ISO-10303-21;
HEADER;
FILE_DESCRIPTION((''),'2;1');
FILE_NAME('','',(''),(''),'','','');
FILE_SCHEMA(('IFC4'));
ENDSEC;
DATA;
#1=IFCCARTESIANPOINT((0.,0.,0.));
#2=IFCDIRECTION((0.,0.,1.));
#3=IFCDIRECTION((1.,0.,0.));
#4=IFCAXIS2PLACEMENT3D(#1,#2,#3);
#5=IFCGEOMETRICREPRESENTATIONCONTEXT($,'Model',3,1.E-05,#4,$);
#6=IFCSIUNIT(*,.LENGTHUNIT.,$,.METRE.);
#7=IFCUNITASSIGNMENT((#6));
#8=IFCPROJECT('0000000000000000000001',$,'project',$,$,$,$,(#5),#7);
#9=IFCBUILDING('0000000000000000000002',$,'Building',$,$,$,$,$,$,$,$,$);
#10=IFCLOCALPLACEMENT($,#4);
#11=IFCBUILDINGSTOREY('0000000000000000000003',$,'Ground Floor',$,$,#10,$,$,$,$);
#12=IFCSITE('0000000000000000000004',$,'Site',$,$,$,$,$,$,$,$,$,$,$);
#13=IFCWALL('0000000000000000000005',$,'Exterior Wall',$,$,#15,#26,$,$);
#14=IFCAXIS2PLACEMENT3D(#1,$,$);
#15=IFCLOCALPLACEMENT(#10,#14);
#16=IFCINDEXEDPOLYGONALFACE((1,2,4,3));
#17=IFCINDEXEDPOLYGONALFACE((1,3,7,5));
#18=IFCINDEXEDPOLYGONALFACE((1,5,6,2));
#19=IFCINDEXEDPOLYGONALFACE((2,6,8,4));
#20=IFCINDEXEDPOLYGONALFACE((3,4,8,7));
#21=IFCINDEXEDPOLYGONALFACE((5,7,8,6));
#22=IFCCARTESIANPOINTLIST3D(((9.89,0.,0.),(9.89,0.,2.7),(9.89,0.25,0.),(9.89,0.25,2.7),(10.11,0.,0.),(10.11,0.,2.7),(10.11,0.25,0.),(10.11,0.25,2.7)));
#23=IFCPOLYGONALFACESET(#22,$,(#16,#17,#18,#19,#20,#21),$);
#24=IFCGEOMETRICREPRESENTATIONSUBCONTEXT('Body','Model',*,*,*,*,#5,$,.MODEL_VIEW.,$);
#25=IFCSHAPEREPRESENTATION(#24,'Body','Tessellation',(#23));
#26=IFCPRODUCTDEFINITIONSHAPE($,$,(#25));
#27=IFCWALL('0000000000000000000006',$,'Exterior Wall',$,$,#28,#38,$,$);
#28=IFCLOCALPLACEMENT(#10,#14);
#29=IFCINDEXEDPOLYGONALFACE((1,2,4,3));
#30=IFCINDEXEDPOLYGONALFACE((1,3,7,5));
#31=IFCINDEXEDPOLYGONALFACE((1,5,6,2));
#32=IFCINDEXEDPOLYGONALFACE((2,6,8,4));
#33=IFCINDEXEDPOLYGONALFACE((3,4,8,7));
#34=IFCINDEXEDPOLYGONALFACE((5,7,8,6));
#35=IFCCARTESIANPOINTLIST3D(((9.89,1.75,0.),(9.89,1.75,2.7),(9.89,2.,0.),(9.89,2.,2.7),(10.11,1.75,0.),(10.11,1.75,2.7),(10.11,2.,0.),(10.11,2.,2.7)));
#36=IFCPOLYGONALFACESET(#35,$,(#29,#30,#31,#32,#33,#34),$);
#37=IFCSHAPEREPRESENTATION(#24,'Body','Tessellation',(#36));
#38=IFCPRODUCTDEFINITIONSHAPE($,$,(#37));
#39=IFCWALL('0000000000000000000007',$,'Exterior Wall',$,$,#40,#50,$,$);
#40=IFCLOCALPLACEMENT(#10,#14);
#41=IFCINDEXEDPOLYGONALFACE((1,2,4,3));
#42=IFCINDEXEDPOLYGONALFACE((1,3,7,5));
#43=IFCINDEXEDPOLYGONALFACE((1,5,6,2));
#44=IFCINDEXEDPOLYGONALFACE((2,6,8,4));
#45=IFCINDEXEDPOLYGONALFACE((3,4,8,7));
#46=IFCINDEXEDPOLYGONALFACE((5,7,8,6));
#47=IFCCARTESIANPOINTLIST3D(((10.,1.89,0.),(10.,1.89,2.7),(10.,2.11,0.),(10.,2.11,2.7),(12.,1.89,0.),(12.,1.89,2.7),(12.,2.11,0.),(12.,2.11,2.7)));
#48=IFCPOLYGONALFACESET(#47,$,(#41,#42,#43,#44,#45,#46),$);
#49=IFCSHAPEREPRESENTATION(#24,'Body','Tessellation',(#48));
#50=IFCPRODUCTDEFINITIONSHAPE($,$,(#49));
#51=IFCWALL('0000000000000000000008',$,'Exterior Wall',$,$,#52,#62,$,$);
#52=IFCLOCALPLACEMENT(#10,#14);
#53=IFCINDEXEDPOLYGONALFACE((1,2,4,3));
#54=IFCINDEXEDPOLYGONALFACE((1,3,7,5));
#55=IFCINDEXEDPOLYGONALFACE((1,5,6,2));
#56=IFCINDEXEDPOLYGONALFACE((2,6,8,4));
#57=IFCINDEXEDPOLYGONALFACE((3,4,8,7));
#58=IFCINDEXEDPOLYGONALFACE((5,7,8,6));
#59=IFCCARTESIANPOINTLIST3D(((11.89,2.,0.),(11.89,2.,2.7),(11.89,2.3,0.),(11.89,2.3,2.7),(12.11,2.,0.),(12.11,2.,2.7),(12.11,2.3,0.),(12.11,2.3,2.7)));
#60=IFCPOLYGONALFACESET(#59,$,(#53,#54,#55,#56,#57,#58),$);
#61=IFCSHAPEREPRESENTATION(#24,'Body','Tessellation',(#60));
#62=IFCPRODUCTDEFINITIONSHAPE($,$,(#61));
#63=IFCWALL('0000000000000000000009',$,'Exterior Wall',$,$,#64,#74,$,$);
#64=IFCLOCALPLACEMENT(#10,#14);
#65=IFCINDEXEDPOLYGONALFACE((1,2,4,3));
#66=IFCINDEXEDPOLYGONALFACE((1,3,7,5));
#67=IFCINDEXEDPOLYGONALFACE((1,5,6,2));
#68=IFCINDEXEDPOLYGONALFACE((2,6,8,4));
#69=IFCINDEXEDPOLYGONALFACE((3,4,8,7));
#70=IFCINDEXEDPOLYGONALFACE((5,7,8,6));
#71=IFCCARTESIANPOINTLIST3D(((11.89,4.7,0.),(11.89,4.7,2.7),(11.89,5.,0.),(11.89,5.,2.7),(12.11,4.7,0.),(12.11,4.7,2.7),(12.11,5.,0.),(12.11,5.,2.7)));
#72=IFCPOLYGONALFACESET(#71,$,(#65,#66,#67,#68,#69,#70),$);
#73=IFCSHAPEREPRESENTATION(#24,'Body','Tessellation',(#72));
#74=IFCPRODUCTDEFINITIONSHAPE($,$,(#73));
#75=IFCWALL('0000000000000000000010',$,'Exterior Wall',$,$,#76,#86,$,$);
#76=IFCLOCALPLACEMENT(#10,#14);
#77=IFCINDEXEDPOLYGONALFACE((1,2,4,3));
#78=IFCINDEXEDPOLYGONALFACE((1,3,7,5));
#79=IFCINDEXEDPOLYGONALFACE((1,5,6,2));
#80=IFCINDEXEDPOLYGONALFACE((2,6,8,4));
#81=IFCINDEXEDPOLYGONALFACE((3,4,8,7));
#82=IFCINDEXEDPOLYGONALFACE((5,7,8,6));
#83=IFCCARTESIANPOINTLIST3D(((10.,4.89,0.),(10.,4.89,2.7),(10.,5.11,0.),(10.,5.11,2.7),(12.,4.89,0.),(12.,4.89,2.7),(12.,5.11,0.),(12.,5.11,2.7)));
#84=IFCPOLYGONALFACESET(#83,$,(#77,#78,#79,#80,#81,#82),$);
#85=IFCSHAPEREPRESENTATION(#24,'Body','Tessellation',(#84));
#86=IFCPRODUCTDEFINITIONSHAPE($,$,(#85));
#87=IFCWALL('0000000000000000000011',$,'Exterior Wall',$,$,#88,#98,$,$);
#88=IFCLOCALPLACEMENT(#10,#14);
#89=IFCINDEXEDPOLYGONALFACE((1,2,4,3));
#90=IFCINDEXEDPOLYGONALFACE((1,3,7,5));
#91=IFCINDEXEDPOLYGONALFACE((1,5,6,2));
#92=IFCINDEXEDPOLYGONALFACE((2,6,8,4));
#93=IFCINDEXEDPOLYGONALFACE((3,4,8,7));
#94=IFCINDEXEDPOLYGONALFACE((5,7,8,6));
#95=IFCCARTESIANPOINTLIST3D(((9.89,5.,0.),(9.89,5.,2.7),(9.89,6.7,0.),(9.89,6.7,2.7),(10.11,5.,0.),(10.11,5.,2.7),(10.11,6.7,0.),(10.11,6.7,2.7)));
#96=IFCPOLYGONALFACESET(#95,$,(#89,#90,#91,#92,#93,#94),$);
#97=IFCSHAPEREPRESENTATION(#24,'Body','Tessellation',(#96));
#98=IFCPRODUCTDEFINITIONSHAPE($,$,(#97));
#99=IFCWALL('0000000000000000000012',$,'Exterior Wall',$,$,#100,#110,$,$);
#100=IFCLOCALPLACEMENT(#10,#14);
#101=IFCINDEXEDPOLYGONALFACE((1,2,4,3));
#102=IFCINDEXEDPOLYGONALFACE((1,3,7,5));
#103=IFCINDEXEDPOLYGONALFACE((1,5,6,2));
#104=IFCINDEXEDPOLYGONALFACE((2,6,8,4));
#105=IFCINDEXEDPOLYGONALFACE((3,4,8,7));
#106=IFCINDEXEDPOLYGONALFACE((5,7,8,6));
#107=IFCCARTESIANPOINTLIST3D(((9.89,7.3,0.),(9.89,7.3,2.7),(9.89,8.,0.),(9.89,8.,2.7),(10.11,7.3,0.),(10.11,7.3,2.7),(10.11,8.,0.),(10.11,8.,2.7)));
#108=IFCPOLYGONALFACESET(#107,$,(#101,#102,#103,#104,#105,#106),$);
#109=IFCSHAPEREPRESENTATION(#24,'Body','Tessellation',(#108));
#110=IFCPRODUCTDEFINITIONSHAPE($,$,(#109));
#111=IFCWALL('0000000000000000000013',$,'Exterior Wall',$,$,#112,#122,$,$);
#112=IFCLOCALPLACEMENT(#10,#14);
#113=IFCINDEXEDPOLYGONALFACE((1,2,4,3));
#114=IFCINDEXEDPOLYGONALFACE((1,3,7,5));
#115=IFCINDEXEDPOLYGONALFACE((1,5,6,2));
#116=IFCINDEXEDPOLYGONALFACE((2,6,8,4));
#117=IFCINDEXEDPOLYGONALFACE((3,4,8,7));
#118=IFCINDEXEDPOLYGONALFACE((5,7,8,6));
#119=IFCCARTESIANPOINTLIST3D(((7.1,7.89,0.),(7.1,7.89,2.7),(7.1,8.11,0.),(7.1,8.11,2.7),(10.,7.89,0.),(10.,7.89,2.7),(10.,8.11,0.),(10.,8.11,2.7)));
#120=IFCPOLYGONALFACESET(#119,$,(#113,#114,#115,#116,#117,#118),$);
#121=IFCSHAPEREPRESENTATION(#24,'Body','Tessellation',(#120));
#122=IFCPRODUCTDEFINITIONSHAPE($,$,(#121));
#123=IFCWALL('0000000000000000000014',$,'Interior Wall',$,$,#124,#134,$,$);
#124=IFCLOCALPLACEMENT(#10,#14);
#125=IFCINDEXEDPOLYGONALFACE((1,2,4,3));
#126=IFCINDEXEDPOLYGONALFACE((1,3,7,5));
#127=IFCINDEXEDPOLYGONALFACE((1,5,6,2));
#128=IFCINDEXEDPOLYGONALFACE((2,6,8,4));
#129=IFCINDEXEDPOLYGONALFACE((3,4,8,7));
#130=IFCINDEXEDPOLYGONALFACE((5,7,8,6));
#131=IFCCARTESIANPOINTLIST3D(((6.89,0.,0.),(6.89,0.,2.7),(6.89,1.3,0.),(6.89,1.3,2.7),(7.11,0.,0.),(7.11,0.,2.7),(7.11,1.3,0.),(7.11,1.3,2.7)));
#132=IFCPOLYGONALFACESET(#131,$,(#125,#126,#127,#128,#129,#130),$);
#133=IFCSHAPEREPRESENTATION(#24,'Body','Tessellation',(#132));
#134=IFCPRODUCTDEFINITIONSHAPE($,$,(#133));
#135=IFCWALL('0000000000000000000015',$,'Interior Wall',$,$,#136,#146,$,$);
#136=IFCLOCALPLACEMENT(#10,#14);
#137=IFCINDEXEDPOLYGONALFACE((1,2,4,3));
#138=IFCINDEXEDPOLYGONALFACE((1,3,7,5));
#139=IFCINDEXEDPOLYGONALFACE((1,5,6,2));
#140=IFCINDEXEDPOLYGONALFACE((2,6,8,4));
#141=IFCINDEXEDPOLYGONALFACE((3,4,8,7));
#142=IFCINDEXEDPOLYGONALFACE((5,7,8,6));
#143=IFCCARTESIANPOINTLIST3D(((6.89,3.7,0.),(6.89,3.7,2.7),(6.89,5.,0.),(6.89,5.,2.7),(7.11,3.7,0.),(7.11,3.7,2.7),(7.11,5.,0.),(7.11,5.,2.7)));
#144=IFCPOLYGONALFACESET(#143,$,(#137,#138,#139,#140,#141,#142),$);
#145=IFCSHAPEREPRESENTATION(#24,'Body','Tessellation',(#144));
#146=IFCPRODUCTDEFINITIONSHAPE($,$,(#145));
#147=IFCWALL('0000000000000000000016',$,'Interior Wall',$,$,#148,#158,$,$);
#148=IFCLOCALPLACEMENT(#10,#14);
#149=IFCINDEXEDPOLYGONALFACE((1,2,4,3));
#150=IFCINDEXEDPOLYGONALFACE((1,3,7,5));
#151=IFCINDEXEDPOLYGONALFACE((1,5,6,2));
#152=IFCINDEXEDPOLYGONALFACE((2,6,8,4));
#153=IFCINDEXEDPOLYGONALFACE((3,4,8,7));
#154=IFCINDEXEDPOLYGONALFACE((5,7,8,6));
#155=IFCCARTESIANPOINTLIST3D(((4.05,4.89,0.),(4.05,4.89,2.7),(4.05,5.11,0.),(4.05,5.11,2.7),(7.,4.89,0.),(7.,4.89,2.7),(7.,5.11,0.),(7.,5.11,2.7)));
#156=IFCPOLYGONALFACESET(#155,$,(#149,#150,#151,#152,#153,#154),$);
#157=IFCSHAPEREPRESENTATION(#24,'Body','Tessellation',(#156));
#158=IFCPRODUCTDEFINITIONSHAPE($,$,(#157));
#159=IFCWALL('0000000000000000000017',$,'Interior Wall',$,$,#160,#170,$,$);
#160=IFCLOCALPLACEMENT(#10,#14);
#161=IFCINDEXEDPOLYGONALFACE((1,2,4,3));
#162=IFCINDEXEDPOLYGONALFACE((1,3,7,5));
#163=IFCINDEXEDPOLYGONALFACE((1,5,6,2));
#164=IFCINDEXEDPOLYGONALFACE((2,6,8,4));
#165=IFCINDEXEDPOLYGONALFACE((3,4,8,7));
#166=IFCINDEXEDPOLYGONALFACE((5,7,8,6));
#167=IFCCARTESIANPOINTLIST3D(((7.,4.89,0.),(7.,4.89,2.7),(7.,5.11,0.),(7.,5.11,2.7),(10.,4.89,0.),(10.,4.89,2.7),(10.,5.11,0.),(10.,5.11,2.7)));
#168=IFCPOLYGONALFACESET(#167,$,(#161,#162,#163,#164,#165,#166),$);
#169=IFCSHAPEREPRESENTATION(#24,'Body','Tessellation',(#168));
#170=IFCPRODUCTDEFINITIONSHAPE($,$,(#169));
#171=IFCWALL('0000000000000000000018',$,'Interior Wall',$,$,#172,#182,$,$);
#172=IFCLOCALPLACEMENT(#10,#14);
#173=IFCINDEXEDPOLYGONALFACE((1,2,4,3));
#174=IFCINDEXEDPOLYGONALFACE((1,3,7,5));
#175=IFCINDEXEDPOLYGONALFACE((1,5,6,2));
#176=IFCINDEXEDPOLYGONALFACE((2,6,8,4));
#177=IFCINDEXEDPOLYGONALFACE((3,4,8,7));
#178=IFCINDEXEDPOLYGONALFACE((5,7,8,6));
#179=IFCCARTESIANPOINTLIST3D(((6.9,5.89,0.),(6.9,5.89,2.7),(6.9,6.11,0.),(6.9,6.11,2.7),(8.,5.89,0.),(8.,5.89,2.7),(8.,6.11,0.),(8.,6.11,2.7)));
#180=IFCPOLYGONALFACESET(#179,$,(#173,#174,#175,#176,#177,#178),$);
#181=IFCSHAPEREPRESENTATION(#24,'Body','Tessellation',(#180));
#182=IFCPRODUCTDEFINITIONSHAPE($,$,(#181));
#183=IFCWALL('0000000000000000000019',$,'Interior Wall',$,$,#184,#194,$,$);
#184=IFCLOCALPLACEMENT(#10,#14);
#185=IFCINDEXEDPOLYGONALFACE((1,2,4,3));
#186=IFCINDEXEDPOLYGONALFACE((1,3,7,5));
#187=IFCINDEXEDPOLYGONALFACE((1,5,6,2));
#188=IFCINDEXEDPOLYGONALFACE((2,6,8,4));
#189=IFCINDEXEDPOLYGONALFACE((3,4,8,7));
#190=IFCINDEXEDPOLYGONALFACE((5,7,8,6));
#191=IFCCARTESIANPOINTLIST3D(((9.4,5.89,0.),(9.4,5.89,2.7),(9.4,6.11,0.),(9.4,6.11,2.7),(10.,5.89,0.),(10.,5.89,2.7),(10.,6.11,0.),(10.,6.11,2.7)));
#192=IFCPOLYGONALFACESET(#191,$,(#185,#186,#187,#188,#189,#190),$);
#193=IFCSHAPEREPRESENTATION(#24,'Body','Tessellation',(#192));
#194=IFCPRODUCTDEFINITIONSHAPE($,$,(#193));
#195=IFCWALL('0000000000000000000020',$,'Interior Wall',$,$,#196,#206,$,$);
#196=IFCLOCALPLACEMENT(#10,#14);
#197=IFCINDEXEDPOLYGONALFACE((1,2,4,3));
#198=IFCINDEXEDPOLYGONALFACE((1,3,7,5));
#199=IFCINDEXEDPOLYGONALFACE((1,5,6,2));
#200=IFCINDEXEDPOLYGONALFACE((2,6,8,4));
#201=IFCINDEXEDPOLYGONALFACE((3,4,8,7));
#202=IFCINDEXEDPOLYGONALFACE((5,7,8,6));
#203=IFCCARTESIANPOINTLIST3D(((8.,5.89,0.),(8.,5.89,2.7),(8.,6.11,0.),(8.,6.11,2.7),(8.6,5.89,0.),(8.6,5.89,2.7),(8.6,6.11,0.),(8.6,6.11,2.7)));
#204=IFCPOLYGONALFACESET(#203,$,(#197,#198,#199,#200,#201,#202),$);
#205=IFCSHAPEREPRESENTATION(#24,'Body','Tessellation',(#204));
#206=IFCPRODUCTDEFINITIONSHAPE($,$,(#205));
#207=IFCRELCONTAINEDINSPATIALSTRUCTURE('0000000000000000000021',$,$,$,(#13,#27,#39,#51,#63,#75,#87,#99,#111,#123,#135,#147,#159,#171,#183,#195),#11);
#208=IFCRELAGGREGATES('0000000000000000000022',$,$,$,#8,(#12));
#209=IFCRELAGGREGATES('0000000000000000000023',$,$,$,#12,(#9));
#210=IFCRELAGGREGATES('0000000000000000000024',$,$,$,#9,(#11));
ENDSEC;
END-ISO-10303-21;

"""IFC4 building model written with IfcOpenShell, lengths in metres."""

from ifc_helpers import new_model, si_unit, frame, origin_with_axes, place, context, subcontext, project, spatial, indexed_curve, outline, extrude, element, save


model = new_model("IFC4")

# Units and contexts
model_context = context("Model", 3, precision=1e-05, world=origin_with_axes())
body_context = subcontext(model_context, "Body", "Model", "MODEL_VIEW")
ifc_project = project(units=[si_unit("LENGTHUNIT", "METRE")], contexts=[model_context])

# Site, building, storey
site = spatial("IfcSite", under=ifc_project, Name="Site")
building = spatial("IfcBuilding", under=site, Name="Building")
storey_placement = place(None, origin_with_axes())
storey = spatial("IfcBuildingStorey", under=building, at=storey_placement, Name="Ground Floor")

# Walls
for number, where, z_axis, x_axis, name in (
    (1, (10.0, 0.0, 0.0), (0.0, 0.0, 1.0), (0.0, 1.0, 0.0), "Exterior Wall"),
    (2, (10.0, 1.75, 0.0), (0.0, 0.0, 1.0), (0.0, 1.0, 0.0), "Exterior Wall"),
):
    element("IfcWall", number, at=place(storey_placement, frame(where, z_axis=z_axis, x_axis=x_axis)), inside=storey, Name=name, context=body_context, shape_type="SweptSolid", body=[
        extrude(outline(indexed_curve([(0.0, 0.0), (0.0, 0.22), (0.25, 0.22), (0.25, 0.0), (0.0, 0.0)], self_intersect=False)), frame((0.0, -0.11, 0.0), z_axis=(0.0, 0.0, 1.0), x_axis=(1.0, 0.0, 0.0)), (0.0, 0.0, 1.0), 2.7),
    ])
wall_1_placement = place(storey_placement, frame((10.0, 2.0, 0.0), z_axis=(0.0, 0.0, 1.0), x_axis=(1.0, 0.0, 0.0)))
element("IfcWall", 3, at=wall_1_placement, inside=storey, Name="Exterior Wall", context=body_context, shape_type="SweptSolid", body=[
    extrude(outline(indexed_curve([(0.0, 0.0), (0.0, 0.22), (2.0, 0.22), (2.0, 0.0), (0.0, 0.0)], self_intersect=False)), frame((0.0, -0.11, 0.0), z_axis=(0.0, 0.0, 1.0), x_axis=(1.0, 0.0, 0.0)), (0.0, 0.0, 1.0), 2.7),
])
for number, where, z_axis, x_axis, name in (
    (4, (12.0, 2.0, 0.0), (0.0, 0.0, 1.0), (0.0, 1.0, 0.0), "Exterior Wall"),
    (5, (12.0, 4.7, 0.0), (0.0, 0.0, 1.0), (0.0, 1.0, 0.0), "Exterior Wall"),
):
    element("IfcWall", number, at=place(storey_placement, frame(where, z_axis=z_axis, x_axis=x_axis)), inside=storey, Name=name, context=body_context, shape_type="SweptSolid", body=[
        extrude(outline(indexed_curve([(0.0, 0.0), (0.0, 0.22), (0.3, 0.22), (0.3, 0.0), (0.0, 0.0)], self_intersect=False)), frame((0.0, -0.11, 0.0), z_axis=(0.0, 0.0, 1.0), x_axis=(1.0, 0.0, 0.0)), (0.0, 0.0, 1.0), 2.7),
    ])
wall_2_placement = place(storey_placement, frame((12.0, 5.0, 0.0), z_axis=(0.0, 0.0, 1.0), x_axis=(-1.0, 0.0, 0.0)))
element("IfcWall", 6, at=wall_2_placement, inside=storey, Name="Exterior Wall", context=body_context, shape_type="SweptSolid", body=[
    extrude(outline(indexed_curve([(0.0, 0.0), (0.0, 0.22), (2.0, 0.22), (2.0, 0.0), (0.0, 0.0)], self_intersect=False)), frame((0.0, -0.11, 0.0), z_axis=(0.0, 0.0, 1.0), x_axis=(1.0, 0.0, 0.0)), (0.0, 0.0, 1.0), 2.7),
])
wall_3_placement = place(storey_placement, frame((10.0, 5.0, 0.0), z_axis=(0.0, 0.0, 1.0), x_axis=(0.0, 1.0, 0.0)))
element("IfcWall", 7, at=wall_3_placement, inside=storey, Name="Exterior Wall", context=body_context, shape_type="SweptSolid", body=[
    extrude(outline(indexed_curve([(0.0, 0.0), (0.0, 0.22), (1.7, 0.22), (1.7, 0.0), (0.0, 0.0)], self_intersect=False)), frame((0.0, -0.11, 0.0), z_axis=(0.0, 0.0, 1.0), x_axis=(1.0, 0.0, 0.0)), (0.0, 0.0, 1.0), 2.7),
])
wall_4_placement = place(storey_placement, frame((10.0, 7.3, 0.0), z_axis=(0.0, 0.0, 1.0), x_axis=(0.0, 1.0, 0.0)))
element("IfcWall", 8, at=wall_4_placement, inside=storey, Name="Exterior Wall", context=body_context, shape_type="SweptSolid", body=[
    extrude(outline(indexed_curve([(0.0, 0.0), (0.0, 0.22), (0.7, 0.22), (0.7, 0.0), (0.0, 0.0)], self_intersect=False)), frame((0.0, -0.11, 0.0), z_axis=(0.0, 0.0, 1.0), x_axis=(1.0, 0.0, 0.0)), (0.0, 0.0, 1.0), 2.7),
])
wall_5_placement = place(storey_placement, frame((10.0, 8.0, 0.0), z_axis=(0.0, 0.0, 1.0), x_axis=(-1.0, 0.0, 0.0)))
element("IfcWall", 9, at=wall_5_placement, inside=storey, Name="Exterior Wall", context=body_context, shape_type="SweptSolid", body=[
    extrude(outline(indexed_curve([(0.0, 0.0), (0.0, 0.22), (2.9, 0.22), (2.9, 0.0), (0.0, 0.0)], self_intersect=False)), frame((0.0, -0.11, 0.0), z_axis=(0.0, 0.0, 1.0), x_axis=(1.0, 0.0, 0.0)), (0.0, 0.0, 1.0), 2.7),
])
wall_6_placement = place(storey_placement, frame((7.0, 0.0, 0.0), z_axis=(0.0, 0.0, 1.0), x_axis=(0.0, 1.0, 0.0)))
element("IfcWall", 10, at=wall_6_placement, inside=storey, Name="Interior Wall", context=body_context, shape_type="SweptSolid", body=[
    extrude(outline(indexed_curve([(0.0, 0.0), (0.0, 0.22), (1.3, 0.22), (1.3, 0.0), (0.0, 0.0)], self_intersect=False)), frame((0.0, -0.11, 0.0), z_axis=(0.0, 0.0, 1.0), x_axis=(1.0, 0.0, 0.0)), (0.0, 0.0, 1.0), 2.7),
])
wall_7_placement = place(storey_placement, frame((7.0, 3.7, 0.0), z_axis=(0.0, 0.0, 1.0), x_axis=(0.0, 1.0, 0.0)))
element("IfcWall", 11, at=wall_7_placement, inside=storey, Name="Interior Wall", context=body_context, shape_type="SweptSolid", body=[
    extrude(outline(indexed_curve([(0.0, 0.0), (0.0, 0.22), (1.3, 0.22), (1.3, 0.0), (0.0, 0.0)], self_intersect=False)), frame((0.0, -0.11, 0.0), z_axis=(0.0, 0.0, 1.0), x_axis=(1.0, 0.0, 0.0)), (0.0, 0.0, 1.0), 2.7),
])
wall_8_placement = place(storey_placement, frame((7.0, 5.0, 0.0), z_axis=(0.0, 0.0, 1.0), x_axis=(-1.0, 0.0, 0.0)))
element("IfcWall", 12, at=wall_8_placement, inside=storey, Name="Interior Wall", context=body_context, shape_type="SweptSolid", body=[
    extrude(outline(indexed_curve([(0.0, 0.0), (0.0, 0.22), (2.95, 0.22), (2.95, 0.0), (0.0, 0.0)], self_intersect=False)), frame((0.0, -0.11, 0.0), z_axis=(0.0, 0.0, 1.0), x_axis=(1.0, 0.0, 0.0)), (0.0, 0.0, 1.0), 2.7),
])
wall_9_placement = place(storey_placement, frame((10.0, 5.0, 0.0), z_axis=(0.0, 0.0, 1.0), x_axis=(-1.0, 0.0, 0.0)))
element("IfcWall", 13, at=wall_9_placement, inside=storey, Name="Interior Wall", context=body_context, shape_type="SweptSolid", body=[
    extrude(outline(indexed_curve([(0.0, 0.0), (0.0, 0.22), (3.0, 0.22), (3.0, 0.0), (0.0, 0.0)], self_intersect=False)), frame((0.0, -0.11, 0.0), z_axis=(0.0, 0.0, 1.0), x_axis=(1.0, 0.0, 0.0)), (0.0, 0.0, 1.0), 2.7),
])
wall_10_placement = place(storey_placement, frame((8.0, 6.0, 0.0), z_axis=(0.0, 0.0, 1.0), x_axis=(-1.0, 0.0, 0.0)))
element("IfcWall", 14, at=wall_10_placement, inside=storey, Name="Interior Wall", context=body_context, shape_type="SweptSolid", body=[
    extrude(outline(indexed_curve([(0.0, 0.0), (0.0, 0.22), (1.1, 0.22), (1.1, 0.0), (0.0, 0.0)], self_intersect=False)), frame((0.0, -0.11, 0.0), z_axis=(0.0, 0.0, 1.0), x_axis=(1.0, 0.0, 0.0)), (0.0, 0.0, 1.0), 2.7),
])
for number, where, z_axis, x_axis, name in (
    (15, (10.0, 6.0, 0.0), (0.0, 0.0, 1.0), (-1.0, 0.0, 0.0), "Interior Wall"),
    (16, (8.6, 6.0, 0.0), (0.0, 0.0, 1.0), (-1.0, 0.0, 0.0), "Interior Wall"),
):
    element("IfcWall", number, at=place(storey_placement, frame(where, z_axis=z_axis, x_axis=x_axis)), inside=storey, Name=name, context=body_context, shape_type="SweptSolid", body=[
        extrude(outline(indexed_curve([(0.0, 0.0), (0.0, 0.22), (0.6, 0.22), (0.6, 0.0), (0.0, 0.0)], self_intersect=False)), frame((0.0, -0.11, 0.0), z_axis=(0.0, 0.0, 1.0), x_axis=(1.0, 0.0, 0.0)), (0.0, 0.0, 1.0), 2.7),
    ])

save(model, "model.ifc")
